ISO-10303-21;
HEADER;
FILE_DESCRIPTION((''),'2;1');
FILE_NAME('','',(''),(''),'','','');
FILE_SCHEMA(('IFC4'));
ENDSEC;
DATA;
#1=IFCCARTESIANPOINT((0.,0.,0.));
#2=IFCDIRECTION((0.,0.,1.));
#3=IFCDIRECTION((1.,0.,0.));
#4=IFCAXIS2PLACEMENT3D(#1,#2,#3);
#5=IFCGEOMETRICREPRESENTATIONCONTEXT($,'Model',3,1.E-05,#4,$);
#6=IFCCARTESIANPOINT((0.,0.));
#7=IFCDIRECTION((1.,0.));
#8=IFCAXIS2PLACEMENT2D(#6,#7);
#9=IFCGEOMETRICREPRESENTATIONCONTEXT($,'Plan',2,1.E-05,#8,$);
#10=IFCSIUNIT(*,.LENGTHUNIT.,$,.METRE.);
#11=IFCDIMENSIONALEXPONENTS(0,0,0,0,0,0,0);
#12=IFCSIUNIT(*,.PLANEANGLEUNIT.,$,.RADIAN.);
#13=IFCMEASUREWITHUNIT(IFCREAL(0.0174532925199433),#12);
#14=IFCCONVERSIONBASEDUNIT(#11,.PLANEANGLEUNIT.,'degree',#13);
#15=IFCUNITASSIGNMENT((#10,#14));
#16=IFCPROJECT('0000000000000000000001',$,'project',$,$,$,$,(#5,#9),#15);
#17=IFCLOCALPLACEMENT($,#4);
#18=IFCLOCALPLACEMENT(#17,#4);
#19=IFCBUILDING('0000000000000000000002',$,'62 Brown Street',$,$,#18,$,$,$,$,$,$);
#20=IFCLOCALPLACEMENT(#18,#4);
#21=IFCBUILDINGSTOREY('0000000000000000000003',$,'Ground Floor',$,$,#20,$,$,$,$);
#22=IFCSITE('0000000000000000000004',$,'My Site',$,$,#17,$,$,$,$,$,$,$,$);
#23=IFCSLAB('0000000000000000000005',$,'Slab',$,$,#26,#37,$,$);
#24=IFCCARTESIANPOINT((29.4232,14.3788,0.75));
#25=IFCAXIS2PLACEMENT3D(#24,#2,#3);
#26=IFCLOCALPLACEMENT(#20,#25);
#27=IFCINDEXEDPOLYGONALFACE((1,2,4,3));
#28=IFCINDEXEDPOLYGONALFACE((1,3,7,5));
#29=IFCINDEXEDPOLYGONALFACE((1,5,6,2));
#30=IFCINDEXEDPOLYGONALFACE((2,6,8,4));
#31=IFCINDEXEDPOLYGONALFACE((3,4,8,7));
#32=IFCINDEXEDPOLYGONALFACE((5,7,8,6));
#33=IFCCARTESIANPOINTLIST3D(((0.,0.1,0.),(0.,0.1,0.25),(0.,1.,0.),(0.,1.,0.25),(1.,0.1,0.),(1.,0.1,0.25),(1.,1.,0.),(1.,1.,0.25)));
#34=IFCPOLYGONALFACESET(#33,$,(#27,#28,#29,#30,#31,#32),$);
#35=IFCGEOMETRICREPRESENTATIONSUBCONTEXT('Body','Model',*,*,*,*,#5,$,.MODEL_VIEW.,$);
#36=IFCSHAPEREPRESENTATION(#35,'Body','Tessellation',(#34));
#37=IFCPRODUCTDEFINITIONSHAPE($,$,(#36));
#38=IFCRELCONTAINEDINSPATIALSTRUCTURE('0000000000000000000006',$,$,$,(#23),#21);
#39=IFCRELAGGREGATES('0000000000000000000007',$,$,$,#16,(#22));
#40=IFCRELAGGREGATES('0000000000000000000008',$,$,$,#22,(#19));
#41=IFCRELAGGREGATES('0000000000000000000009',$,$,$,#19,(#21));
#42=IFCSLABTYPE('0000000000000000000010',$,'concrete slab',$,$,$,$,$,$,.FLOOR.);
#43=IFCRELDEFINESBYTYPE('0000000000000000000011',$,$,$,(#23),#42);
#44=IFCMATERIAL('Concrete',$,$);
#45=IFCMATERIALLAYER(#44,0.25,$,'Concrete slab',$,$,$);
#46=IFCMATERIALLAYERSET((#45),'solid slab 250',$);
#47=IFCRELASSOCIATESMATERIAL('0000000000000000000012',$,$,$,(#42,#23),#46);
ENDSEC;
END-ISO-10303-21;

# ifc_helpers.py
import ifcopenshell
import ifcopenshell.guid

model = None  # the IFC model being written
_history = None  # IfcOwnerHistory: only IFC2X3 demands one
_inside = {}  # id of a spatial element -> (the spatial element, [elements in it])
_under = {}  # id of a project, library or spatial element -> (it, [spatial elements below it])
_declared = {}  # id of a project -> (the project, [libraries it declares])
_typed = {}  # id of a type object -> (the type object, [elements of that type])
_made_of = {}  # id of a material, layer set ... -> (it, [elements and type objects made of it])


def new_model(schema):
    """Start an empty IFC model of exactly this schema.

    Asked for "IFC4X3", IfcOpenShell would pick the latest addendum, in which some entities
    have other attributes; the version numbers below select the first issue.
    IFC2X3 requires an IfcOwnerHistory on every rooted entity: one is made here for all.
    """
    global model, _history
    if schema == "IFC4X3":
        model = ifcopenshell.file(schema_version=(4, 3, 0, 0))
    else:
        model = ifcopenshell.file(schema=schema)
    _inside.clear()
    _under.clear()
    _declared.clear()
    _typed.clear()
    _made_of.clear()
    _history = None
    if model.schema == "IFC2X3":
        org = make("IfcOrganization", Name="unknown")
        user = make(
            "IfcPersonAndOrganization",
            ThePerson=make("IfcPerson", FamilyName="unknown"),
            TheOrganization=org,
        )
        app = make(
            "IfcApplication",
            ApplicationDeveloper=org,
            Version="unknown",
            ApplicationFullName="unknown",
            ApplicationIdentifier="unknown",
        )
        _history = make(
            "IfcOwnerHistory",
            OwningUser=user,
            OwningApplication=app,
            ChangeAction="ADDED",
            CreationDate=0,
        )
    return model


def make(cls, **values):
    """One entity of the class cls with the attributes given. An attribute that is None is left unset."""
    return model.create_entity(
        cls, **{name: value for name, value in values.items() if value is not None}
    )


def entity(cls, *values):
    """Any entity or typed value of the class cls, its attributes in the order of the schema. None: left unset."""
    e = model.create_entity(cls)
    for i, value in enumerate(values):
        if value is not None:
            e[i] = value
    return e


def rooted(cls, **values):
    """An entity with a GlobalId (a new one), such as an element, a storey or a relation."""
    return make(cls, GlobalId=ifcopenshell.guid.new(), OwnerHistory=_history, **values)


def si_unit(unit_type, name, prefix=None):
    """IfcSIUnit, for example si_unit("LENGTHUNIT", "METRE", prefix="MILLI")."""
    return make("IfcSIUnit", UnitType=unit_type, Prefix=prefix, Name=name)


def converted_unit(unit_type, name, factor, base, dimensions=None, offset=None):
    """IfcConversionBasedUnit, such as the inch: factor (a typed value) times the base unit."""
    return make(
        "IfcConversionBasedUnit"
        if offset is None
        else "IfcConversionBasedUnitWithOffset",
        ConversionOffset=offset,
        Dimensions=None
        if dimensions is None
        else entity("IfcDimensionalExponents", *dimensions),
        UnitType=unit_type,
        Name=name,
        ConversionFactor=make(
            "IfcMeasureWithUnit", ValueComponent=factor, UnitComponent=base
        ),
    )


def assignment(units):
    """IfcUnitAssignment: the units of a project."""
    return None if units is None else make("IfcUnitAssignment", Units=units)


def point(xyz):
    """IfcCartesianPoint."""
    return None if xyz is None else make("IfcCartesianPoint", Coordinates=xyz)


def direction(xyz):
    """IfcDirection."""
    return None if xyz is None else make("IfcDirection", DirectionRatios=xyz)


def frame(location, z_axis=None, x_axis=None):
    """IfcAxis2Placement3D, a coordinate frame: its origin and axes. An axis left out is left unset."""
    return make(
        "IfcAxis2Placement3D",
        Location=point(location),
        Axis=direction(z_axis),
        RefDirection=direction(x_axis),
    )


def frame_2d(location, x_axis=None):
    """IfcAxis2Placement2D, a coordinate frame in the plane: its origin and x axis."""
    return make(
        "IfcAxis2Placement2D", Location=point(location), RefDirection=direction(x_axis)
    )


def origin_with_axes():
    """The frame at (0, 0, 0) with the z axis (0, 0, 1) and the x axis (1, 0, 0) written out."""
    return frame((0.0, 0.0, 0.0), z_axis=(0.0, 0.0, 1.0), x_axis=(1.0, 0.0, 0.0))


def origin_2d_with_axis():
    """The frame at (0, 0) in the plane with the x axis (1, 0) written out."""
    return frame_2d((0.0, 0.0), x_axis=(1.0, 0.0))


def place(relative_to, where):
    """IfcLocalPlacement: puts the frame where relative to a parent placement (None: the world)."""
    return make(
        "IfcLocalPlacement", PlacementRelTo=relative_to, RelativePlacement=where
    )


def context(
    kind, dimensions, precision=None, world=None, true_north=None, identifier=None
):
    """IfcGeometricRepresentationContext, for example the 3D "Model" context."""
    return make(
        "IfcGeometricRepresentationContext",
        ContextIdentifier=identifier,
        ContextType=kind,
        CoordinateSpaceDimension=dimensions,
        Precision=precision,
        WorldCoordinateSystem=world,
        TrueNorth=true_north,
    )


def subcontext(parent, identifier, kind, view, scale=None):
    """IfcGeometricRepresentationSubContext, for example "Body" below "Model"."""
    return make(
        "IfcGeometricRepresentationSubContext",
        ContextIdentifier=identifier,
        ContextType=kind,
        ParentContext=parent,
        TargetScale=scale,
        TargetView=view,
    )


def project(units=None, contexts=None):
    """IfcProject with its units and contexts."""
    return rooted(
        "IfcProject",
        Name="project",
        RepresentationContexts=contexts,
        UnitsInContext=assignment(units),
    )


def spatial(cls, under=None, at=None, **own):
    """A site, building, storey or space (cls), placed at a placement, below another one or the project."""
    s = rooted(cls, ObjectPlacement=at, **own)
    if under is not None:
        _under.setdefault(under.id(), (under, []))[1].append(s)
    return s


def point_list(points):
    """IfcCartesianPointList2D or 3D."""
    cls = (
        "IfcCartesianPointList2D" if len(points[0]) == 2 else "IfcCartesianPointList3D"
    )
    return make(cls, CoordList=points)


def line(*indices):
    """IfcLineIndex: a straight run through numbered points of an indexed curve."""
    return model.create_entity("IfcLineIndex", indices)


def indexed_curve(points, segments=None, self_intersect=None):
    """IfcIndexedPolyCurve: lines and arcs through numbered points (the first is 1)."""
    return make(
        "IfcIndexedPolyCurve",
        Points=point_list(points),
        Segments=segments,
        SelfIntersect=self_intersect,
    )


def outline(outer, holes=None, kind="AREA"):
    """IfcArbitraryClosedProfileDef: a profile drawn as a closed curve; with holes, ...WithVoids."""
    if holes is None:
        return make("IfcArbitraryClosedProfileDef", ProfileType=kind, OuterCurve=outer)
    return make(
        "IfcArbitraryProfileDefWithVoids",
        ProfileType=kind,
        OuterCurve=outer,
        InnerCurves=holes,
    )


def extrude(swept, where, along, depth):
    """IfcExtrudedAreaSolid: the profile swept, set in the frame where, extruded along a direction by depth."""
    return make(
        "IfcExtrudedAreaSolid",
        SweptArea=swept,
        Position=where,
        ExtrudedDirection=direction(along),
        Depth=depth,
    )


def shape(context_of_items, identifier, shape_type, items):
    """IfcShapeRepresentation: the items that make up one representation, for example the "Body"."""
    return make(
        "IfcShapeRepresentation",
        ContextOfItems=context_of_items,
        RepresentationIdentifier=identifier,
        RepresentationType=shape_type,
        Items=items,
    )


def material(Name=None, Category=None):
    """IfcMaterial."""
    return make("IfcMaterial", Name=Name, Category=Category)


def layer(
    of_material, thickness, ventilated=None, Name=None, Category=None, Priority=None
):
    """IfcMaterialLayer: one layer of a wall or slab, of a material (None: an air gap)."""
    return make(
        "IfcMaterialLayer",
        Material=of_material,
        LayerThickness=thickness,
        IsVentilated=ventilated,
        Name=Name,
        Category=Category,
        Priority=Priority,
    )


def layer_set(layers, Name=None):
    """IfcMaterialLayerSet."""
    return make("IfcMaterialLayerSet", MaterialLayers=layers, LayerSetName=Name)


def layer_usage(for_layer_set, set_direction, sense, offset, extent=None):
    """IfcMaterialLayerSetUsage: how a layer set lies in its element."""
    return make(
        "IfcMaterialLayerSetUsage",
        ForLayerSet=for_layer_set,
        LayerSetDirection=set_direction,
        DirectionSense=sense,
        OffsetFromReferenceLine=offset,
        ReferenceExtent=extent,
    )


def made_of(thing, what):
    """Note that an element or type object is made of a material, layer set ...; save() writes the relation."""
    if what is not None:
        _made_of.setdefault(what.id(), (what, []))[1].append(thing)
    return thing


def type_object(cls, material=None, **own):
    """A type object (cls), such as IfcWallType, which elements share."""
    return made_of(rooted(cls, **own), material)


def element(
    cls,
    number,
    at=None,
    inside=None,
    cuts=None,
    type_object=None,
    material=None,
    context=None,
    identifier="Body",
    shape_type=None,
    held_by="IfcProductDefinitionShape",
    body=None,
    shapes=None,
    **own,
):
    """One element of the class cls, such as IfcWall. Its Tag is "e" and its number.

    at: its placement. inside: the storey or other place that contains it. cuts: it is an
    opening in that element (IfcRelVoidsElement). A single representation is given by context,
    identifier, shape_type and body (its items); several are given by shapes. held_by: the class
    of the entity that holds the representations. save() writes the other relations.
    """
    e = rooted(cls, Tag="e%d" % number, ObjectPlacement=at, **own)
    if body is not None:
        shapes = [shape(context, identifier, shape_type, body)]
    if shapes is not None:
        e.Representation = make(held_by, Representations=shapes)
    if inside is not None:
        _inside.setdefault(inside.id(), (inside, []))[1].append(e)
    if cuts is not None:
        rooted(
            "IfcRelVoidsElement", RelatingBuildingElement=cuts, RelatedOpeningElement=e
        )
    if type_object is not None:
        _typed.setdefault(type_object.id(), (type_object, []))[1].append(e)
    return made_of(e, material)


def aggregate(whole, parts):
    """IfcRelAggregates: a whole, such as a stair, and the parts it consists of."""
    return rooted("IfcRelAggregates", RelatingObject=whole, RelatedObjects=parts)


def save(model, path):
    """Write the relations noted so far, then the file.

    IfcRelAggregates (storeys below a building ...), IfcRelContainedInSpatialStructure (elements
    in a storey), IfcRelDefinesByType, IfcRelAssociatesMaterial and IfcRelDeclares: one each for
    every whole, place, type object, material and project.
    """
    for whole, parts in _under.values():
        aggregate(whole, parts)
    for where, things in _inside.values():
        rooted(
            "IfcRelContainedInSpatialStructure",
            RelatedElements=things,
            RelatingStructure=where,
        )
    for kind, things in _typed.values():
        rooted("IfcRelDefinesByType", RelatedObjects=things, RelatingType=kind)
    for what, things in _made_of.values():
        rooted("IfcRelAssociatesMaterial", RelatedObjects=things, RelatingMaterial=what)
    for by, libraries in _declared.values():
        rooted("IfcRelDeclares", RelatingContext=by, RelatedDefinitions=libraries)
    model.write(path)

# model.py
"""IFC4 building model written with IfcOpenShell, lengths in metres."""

from ifc_helpers import new_model, entity, si_unit, converted_unit, frame, origin_with_axes, origin_2d_with_axis, place, context, subcontext, project, spatial, line, indexed_curve, outline, extrude, material, layer, layer_set, layer_usage, type_object, element, save


model = new_model("IFC4")

# Units and contexts
model_context = context("Model", 3, precision=1e-05, world=origin_with_axes())
plan_context = context("Plan", 2, precision=1e-05, world=origin_2d_with_axis())
body_context_1 = subcontext(model_context, "Body", "Model", "MODEL_VIEW")
ifc_project = project(units=[si_unit("LENGTHUNIT", "METRE"), converted_unit("PLANEANGLEUNIT", "degree", entity("IfcReal", 0.0174532925199433), si_unit("PLANEANGLEUNIT", "RADIAN"), dimensions=[0, 0, 0, 0, 0, 0, 0])], contexts=[model_context, plan_context])

# Site, building, storey
site_placement = place(None, origin_with_axes())
site = spatial("IfcSite", under=ifc_project, at=site_placement, Name="My Site")
building_placement = place(site_placement, origin_with_axes())
building = spatial("IfcBuilding", under=site, at=building_placement, Name="62 Brown Street")
storey_placement = place(building_placement, origin_with_axes())
storey = spatial("IfcBuildingStorey", under=building, at=storey_placement, Name="Ground Floor")

# Shared definitions
ifc_material_1 = material(Name="Concrete")

# Slab
ifc_layer_1 = layer(ifc_material_1, 0.25, Name="Concrete slab")
ifc_layer_set_1 = layer_set([ifc_layer_1], Name="solid slab 250")
ifc_layer_usage_1 = layer_usage(ifc_layer_set_1, "AXIS3", "POSITIVE", 0.0)
slab_type = type_object("IfcSlabType", Name="concrete slab", PredefinedType="FLOOR", material=ifc_layer_set_1)
slab_1_placement = place(storey_placement, frame((29.4232, 14.3788, 0.75), z_axis=(0.0, 0.0, 1.0), x_axis=(1.0, 0.0, 0.0)))
element("IfcSlab", 1, at=slab_1_placement, inside=storey, type_object=slab_type, material=ifc_layer_usage_1, Name="Slab", context=body_context_1, shape_type="SweptSolid", body=[
    extrude(outline(indexed_curve([(1.0, 1.0), (1.0, 0.1), (0.0, 0.1), (0.0, 1.0)], segments=[line(3, 2), line(2, 1), line(1, 4), line(4, 3)], self_intersect=False)), None, (0.0, 0.0, 1.0), 0.25),
])

save(model, "model.ifc")
